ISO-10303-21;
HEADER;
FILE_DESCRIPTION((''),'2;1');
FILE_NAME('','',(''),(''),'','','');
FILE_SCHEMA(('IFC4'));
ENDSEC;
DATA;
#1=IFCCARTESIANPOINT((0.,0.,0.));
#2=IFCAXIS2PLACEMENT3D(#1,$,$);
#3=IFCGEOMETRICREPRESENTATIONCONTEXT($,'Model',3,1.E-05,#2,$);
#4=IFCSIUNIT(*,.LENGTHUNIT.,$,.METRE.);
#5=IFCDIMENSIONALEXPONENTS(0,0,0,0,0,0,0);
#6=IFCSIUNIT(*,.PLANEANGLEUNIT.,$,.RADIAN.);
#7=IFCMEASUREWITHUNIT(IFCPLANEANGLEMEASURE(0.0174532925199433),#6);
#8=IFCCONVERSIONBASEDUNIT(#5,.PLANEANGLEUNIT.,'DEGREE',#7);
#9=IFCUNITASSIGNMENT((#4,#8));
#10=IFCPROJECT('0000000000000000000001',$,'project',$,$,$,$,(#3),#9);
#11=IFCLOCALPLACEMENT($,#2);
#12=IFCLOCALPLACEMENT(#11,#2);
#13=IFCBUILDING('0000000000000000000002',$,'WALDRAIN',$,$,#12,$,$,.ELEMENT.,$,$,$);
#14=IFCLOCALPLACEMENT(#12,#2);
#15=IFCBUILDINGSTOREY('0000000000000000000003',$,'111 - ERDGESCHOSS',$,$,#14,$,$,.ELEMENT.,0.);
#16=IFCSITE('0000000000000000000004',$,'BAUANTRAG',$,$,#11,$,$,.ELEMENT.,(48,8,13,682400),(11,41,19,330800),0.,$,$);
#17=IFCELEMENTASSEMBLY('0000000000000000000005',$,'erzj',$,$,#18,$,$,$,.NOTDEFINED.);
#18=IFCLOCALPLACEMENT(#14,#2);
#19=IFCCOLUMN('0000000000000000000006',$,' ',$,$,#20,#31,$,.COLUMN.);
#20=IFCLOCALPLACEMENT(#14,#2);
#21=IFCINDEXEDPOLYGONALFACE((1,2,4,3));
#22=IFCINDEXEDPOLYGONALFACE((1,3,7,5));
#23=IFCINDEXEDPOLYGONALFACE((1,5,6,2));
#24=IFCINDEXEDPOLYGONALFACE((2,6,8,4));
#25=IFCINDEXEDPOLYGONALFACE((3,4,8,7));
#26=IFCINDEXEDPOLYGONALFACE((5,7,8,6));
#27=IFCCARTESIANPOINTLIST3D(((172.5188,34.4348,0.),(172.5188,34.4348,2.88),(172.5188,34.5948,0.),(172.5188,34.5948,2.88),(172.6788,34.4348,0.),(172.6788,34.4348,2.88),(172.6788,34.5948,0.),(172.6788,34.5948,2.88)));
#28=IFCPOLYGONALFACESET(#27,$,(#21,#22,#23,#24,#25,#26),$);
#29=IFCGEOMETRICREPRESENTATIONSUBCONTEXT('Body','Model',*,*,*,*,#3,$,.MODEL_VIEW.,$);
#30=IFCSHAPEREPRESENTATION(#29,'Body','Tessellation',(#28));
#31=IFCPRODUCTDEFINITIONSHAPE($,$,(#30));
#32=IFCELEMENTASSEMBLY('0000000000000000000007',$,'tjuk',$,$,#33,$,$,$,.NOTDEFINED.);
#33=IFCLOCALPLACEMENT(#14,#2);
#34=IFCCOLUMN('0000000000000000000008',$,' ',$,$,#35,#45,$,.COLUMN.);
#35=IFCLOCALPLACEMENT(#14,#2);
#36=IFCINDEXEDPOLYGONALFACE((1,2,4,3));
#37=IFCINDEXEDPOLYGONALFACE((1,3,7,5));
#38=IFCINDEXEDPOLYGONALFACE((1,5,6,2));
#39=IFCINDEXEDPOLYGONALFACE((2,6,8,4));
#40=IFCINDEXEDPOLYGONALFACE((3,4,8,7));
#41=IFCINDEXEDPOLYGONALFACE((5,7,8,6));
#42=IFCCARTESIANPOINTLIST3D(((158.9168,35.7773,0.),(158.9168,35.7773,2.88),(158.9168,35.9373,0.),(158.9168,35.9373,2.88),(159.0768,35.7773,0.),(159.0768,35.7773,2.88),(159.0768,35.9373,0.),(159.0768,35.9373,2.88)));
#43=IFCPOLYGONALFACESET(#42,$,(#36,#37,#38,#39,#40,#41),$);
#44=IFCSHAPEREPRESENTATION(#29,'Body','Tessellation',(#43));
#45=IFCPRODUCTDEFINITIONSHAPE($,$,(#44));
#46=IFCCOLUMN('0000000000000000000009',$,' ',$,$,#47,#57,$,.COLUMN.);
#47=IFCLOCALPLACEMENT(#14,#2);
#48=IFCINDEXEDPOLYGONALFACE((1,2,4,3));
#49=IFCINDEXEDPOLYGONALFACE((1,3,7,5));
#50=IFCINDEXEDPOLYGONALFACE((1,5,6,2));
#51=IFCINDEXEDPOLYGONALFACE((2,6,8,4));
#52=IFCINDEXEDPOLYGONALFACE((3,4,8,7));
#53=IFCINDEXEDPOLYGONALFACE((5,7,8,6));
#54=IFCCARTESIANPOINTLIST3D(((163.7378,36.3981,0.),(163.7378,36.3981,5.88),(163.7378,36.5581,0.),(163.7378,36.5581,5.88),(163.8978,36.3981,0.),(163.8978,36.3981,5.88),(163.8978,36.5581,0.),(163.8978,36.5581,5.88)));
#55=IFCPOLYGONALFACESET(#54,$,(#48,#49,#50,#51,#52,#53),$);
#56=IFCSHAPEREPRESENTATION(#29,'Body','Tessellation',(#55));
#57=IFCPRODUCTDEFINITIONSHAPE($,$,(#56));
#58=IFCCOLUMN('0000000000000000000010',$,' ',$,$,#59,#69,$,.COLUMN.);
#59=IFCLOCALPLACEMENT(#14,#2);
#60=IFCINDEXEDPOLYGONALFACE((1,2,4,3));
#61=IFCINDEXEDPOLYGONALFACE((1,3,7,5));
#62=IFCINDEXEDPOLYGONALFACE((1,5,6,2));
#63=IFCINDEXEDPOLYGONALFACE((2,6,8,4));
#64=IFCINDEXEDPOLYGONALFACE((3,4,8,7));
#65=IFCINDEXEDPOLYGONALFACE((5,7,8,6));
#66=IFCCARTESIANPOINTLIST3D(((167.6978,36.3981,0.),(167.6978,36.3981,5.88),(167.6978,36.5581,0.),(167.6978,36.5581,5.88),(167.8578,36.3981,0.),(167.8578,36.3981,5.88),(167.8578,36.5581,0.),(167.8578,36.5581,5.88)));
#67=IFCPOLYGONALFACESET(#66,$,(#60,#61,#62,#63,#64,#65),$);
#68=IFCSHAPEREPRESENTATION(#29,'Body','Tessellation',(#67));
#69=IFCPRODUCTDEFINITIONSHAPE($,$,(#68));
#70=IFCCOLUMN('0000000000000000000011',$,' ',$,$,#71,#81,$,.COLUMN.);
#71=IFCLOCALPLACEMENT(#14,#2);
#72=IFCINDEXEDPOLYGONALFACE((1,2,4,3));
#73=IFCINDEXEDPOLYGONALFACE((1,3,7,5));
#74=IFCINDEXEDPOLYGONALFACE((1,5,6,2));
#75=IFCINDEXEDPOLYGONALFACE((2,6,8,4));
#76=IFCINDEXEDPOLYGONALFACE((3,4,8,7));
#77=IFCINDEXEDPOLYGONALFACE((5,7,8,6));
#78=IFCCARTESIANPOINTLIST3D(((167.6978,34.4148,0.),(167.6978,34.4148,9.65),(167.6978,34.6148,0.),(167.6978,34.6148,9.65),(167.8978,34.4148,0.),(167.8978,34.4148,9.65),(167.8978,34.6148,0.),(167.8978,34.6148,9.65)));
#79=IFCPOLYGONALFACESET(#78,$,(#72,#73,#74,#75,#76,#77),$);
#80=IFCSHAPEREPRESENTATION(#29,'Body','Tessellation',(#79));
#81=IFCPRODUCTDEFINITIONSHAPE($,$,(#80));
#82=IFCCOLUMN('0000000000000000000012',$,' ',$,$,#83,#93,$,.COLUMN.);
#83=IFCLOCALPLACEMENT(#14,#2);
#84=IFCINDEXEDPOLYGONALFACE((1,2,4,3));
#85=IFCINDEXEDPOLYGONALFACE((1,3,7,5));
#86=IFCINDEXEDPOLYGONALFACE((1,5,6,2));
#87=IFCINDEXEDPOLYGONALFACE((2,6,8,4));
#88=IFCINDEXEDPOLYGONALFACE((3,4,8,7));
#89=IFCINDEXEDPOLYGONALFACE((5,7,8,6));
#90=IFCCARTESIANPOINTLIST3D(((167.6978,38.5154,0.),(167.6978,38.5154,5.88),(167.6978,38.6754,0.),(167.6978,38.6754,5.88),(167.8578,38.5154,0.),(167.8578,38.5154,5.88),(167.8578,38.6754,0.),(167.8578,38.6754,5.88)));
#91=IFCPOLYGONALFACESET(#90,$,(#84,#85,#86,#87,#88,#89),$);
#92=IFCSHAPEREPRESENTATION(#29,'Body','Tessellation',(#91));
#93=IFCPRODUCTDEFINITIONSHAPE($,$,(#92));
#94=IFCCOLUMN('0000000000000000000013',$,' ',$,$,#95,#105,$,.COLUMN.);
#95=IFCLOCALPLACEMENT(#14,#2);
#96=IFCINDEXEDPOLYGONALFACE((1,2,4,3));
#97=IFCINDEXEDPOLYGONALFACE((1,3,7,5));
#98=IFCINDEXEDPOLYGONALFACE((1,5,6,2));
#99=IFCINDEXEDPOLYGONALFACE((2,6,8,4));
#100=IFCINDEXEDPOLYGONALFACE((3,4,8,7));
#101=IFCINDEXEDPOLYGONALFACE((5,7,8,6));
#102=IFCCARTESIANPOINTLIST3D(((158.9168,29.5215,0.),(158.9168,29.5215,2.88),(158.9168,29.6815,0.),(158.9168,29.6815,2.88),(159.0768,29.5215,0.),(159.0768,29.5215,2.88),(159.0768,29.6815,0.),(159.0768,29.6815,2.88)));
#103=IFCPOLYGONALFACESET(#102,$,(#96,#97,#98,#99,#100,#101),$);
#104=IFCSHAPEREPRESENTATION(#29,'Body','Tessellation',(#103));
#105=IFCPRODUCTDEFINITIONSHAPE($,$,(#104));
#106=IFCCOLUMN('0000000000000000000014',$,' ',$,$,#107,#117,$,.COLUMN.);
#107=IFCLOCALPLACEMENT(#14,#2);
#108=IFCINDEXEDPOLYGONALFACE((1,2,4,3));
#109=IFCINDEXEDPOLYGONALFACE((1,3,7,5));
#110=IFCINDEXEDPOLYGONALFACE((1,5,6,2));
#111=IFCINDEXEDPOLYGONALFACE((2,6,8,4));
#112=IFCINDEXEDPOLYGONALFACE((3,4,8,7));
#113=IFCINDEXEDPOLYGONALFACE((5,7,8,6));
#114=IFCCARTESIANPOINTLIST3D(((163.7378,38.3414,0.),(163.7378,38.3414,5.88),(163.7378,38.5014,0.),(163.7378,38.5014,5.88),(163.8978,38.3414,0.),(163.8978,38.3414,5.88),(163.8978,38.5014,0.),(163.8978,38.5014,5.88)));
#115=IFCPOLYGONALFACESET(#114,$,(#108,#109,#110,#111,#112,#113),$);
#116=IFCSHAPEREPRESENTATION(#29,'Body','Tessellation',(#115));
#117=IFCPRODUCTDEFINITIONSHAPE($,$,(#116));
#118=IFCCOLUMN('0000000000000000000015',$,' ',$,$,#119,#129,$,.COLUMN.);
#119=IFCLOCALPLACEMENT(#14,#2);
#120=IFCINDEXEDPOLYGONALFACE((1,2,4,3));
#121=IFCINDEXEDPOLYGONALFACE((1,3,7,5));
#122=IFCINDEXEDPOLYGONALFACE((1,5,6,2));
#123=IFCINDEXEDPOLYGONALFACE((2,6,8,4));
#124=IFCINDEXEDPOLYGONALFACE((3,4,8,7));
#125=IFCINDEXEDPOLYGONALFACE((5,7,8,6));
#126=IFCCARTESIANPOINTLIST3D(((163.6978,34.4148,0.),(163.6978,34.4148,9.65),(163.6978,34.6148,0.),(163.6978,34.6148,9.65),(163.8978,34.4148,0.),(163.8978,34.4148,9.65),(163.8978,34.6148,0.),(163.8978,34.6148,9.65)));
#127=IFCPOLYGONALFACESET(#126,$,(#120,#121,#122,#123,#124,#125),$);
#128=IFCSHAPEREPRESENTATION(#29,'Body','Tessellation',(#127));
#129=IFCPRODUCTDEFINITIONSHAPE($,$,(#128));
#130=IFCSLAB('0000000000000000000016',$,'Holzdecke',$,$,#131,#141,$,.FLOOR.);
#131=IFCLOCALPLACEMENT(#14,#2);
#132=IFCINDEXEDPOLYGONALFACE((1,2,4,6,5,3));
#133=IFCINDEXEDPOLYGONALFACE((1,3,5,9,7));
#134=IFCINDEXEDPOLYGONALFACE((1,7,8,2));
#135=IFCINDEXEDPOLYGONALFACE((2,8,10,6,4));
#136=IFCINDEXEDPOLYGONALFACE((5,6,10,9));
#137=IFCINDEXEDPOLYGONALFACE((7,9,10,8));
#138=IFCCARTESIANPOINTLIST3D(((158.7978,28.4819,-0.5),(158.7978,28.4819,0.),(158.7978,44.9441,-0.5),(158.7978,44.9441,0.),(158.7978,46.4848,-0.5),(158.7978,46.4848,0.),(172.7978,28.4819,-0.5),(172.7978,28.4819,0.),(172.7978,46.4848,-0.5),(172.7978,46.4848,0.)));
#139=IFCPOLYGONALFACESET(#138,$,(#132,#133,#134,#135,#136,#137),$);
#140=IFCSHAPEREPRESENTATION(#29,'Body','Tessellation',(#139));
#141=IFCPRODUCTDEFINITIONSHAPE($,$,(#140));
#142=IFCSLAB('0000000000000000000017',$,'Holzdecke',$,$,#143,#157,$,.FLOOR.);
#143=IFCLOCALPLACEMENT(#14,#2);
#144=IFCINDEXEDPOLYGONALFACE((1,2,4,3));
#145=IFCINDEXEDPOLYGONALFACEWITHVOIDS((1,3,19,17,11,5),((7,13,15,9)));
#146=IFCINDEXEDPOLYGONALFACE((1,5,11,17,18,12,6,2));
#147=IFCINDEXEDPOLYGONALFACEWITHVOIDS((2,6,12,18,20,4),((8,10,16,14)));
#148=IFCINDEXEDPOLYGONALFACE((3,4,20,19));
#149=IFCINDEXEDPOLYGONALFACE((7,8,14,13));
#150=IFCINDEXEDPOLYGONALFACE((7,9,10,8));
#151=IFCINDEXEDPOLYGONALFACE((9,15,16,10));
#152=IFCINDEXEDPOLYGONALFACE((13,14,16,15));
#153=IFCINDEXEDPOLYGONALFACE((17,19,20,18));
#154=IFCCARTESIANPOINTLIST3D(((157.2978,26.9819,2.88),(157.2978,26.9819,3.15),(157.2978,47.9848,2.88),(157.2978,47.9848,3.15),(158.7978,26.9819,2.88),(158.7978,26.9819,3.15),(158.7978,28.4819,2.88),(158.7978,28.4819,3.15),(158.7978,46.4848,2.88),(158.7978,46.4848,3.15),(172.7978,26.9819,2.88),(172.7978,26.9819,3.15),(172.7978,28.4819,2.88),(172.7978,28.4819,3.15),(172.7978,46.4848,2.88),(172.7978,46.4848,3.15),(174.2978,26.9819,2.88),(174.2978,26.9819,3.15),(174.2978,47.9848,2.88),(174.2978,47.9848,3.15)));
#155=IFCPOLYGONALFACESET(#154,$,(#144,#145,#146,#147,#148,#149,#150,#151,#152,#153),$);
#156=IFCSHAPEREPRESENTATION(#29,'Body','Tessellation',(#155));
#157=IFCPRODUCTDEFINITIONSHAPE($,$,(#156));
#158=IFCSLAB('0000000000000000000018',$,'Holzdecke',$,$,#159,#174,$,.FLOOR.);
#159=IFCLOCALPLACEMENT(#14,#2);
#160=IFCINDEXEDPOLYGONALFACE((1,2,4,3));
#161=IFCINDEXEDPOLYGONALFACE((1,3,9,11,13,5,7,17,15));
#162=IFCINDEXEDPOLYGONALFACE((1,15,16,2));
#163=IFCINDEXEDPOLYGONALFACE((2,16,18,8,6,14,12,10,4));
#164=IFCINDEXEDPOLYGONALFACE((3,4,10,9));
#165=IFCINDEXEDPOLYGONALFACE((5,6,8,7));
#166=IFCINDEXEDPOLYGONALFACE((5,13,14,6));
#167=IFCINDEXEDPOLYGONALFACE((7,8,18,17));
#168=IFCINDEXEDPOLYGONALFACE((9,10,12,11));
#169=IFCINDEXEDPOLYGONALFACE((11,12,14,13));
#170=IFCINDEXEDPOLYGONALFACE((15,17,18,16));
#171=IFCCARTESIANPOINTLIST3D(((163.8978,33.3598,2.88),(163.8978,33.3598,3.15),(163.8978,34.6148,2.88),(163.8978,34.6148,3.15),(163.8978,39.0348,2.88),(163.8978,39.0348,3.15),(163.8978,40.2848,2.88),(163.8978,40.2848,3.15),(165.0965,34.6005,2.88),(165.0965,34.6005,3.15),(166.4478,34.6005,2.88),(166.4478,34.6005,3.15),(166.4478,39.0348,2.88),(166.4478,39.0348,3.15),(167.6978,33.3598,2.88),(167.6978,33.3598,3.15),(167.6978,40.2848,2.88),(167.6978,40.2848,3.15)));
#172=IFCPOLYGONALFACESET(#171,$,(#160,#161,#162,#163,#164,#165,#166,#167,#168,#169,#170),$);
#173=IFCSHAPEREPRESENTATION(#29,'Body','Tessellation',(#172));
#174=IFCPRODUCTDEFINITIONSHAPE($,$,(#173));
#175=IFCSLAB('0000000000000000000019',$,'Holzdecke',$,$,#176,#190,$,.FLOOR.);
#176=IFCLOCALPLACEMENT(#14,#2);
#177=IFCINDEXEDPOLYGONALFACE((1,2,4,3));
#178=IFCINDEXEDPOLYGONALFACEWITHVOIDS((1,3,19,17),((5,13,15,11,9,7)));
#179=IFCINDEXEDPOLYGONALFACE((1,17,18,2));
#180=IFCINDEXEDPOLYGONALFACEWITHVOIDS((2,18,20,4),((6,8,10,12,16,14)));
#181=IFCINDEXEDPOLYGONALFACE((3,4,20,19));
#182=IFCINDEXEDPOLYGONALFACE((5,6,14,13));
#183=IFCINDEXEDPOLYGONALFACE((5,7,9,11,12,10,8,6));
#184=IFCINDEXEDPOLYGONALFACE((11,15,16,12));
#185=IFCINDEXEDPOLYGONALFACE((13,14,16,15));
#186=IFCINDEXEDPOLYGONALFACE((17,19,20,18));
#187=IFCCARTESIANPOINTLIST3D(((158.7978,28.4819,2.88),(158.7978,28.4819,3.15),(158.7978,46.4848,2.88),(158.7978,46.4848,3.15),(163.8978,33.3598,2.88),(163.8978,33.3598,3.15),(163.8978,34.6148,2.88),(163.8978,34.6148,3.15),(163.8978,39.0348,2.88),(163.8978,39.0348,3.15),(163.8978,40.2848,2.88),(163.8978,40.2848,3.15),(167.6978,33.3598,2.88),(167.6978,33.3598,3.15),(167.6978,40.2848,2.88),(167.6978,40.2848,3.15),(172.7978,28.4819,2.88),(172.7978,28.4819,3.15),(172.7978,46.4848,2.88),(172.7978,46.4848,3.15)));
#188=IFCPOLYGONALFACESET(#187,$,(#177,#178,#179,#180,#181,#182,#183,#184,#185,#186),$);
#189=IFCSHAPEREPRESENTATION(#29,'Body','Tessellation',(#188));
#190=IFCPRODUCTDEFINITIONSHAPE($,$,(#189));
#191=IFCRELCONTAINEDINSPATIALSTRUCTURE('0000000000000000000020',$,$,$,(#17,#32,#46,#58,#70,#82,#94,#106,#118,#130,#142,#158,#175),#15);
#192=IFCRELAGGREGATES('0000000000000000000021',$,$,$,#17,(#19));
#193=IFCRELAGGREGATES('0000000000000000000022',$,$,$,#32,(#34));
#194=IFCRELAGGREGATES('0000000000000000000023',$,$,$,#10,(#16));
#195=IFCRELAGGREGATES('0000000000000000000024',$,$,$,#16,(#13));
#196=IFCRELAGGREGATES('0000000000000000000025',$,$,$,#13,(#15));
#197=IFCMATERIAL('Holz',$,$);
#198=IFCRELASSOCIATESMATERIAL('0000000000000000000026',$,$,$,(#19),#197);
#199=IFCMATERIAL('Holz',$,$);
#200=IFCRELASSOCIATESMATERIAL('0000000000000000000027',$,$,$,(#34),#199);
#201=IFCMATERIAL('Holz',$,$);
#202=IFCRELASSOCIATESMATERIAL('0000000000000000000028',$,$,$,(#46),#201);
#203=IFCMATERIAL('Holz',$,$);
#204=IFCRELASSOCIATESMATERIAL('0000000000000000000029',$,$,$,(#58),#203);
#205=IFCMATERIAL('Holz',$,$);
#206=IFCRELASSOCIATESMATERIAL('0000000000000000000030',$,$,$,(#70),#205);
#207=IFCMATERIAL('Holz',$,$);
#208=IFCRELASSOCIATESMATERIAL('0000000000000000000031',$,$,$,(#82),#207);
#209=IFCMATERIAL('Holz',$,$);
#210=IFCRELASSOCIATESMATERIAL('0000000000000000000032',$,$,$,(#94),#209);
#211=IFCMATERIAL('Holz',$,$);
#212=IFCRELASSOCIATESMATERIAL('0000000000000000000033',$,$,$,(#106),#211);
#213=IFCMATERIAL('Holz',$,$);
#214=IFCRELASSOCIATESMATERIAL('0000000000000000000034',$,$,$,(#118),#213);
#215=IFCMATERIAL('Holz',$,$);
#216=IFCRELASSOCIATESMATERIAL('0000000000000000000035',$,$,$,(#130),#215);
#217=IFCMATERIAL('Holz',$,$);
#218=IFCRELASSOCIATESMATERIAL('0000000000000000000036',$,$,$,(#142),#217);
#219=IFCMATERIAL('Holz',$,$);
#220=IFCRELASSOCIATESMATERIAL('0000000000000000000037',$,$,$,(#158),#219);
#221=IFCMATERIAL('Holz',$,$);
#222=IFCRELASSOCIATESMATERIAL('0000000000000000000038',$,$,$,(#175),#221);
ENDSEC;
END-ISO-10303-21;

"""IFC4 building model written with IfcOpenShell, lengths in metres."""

from ifc_helpers import new_model, entity, si_unit, converted_unit, frame, frame_2d, origin, origin_with_axes, place, context, subcontext, project, spatial, polyline, rectangle, outline, extrude, material, element, aggregate, save


model = new_model("IFC4")

# Units and contexts
model_context = context("Model", 3, precision=1e-05, world=origin())
body_context = subcontext(model_context, "Body", "Model", "MODEL_VIEW")
ifc_project = project(units=[si_unit("LENGTHUNIT", "METRE"), converted_unit("PLANEANGLEUNIT", "DEGREE", entity("IfcPlaneAngleMeasure", 0.0174532925199433), si_unit("PLANEANGLEUNIT", "RADIAN"), dimensions=[0, 0, 0, 0, 0, 0, 0])], contexts=[model_context])

# Site, building, storey
site_placement = place(None, origin())
site = spatial("IfcSite", under=ifc_project, at=site_placement, Name="BAUANTRAG", CompositionType="ELEMENT", RefLatitude=(48, 8, 13, 682400), RefLongitude=(11, 41, 19, 330800), RefElevation=0.0)
building_placement = place(site_placement, origin())
building = spatial("IfcBuilding", under=site, at=building_placement, Name="WALDRAIN", CompositionType="ELEMENT")
storey_placement = place(building_placement, origin())
storey = spatial("IfcBuildingStorey", under=building, at=storey_placement, Name="111 - ERDGESCHOSS", CompositionType="ELEMENT", Elevation=0.0)

# Element assemblies, columns
assembly_1_placement = place(storey_placement, origin())
assembly_1 = element("IfcElementAssembly", 1, at=assembly_1_placement, inside=storey, Name="erzj", PredefinedType="NOTDEFINED")
ifc_material_1 = material(Name="Holz")
column_1_placement = place(assembly_1_placement, frame((172.5188, 34.4348, 0.0)))
column_1 = element("IfcColumn", 2, at=column_1_placement, material=ifc_material_1, Name=" ", PredefinedType="COLUMN", context=body_context, shape_type="SweptSolid", body=[
    extrude(rectangle(XDim=0.16, YDim=0.16, at=frame_2d((0.08, 0.08), x_axis=(1.0, 0.0))), origin_with_axes(), (0.0, 0.0, 1.0), 2.88),
])
aggregate(assembly_1, [column_1])
assembly_2_placement = place(storey_placement, origin())
assembly_2 = element("IfcElementAssembly", 3, at=assembly_2_placement, inside=storey, Name="tjuk", PredefinedType="NOTDEFINED")
ifc_material_2 = material(Name="Holz")
column_2_placement = place(assembly_2_placement, frame((158.9168, 35.7773, 0.0)))
column_2 = element("IfcColumn", 4, at=column_2_placement, material=ifc_material_2, Name=" ", PredefinedType="COLUMN", context=body_context, shape_type="SweptSolid", body=[
    extrude(rectangle(XDim=0.16, YDim=0.16, at=frame_2d((0.08, 0.08), x_axis=(1.0, 0.0))), origin_with_axes(), (0.0, 0.0, 1.0), 2.88),
])
aggregate(assembly_2, [column_2])

# Columns
ifc_material_3 = material(Name="Holz")
column_3_placement = place(storey_placement, frame((163.7378, 36.3981, 0.0)))
element("IfcColumn", 5, at=column_3_placement, inside=storey, material=ifc_material_3, Name=" ", PredefinedType="COLUMN", context=body_context, shape_type="SweptSolid", body=[
    extrude(rectangle(XDim=0.16, YDim=0.16, at=frame_2d((0.08, 0.08), x_axis=(1.0, 0.0))), origin_with_axes(), (0.0, 0.0, 1.0), 5.88),
])
ifc_material_4 = material(Name="Holz")
column_4_placement = place(storey_placement, frame((167.6978, 36.3981, 0.0)))
element("IfcColumn", 6, at=column_4_placement, inside=storey, material=ifc_material_4, Name=" ", PredefinedType="COLUMN", context=body_context, shape_type="SweptSolid", body=[
    extrude(rectangle(XDim=0.16, YDim=0.16, at=frame_2d((0.08, 0.08), x_axis=(1.0, 0.0))), origin_with_axes(), (0.0, 0.0, 1.0), 5.88),
])
ifc_material_5 = material(Name="Holz")
column_5_placement = place(storey_placement, frame((167.6978, 34.4148, 0.0)))
element("IfcColumn", 7, at=column_5_placement, inside=storey, material=ifc_material_5, Name=" ", PredefinedType="COLUMN", context=body_context, shape_type="SweptSolid", body=[
    extrude(rectangle(XDim=0.2, YDim=0.2, at=frame_2d((0.1, 0.1), x_axis=(1.0, 0.0))), origin_with_axes(), (0.0, 0.0, 1.0), 9.65),
])
ifc_material_6 = material(Name="Holz")
column_6_placement = place(storey_placement, frame((167.6978, 38.5154, 0.0)))
element("IfcColumn", 8, at=column_6_placement, inside=storey, material=ifc_material_6, Name=" ", PredefinedType="COLUMN", context=body_context, shape_type="SweptSolid", body=[
    extrude(rectangle(XDim=0.16, YDim=0.16, at=frame_2d((0.08, 0.08), x_axis=(1.0, 0.0))), origin_with_axes(), (0.0, 0.0, 1.0), 5.88),
])
ifc_material_7 = material(Name="Holz")
column_7_placement = place(storey_placement, frame((158.9168, 29.5215, 0.0)))
element("IfcColumn", 9, at=column_7_placement, inside=storey, material=ifc_material_7, Name=" ", PredefinedType="COLUMN", context=body_context, shape_type="SweptSolid", body=[
    extrude(rectangle(XDim=0.16, YDim=0.16, at=frame_2d((0.08, 0.08), x_axis=(1.0, 0.0))), origin_with_axes(), (0.0, 0.0, 1.0), 2.88),
])
ifc_material_8 = material(Name="Holz")
column_8_placement = place(storey_placement, frame((163.7378, 38.3414, 0.0)))
element("IfcColumn", 10, at=column_8_placement, inside=storey, material=ifc_material_8, Name=" ", PredefinedType="COLUMN", context=body_context, shape_type="SweptSolid", body=[
    extrude(rectangle(XDim=0.16, YDim=0.16, at=frame_2d((0.08, 0.08), x_axis=(1.0, 0.0))), origin_with_axes(), (0.0, 0.0, 1.0), 5.88),
])
ifc_material_9 = material(Name="Holz")
column_9_placement = place(storey_placement, frame((163.6978, 34.4148, 0.0)))
element("IfcColumn", 11, at=column_9_placement, inside=storey, material=ifc_material_9, Name=" ", PredefinedType="COLUMN", context=body_context, shape_type="SweptSolid", body=[
    extrude(rectangle(XDim=0.2, YDim=0.2, at=frame_2d((0.1, 0.1), x_axis=(1.0, 0.0))), origin_with_axes(), (0.0, 0.0, 1.0), 9.65),
])

# Slabs
ifc_material_10 = material(Name="Holz")
slab_1_placement = place(storey_placement, frame((158.7978, 28.4819, -0.5)))
element("IfcSlab", 12, at=slab_1_placement, inside=storey, material=ifc_material_10, Name="Holzdecke", PredefinedType="FLOOR", context=body_context, shape_type="SweptSolid", body=[
    extrude(outline(polyline([(0.0, 16.4622), (0.0, 0.0), (14.0, 0.0), (14.0, 18.0029), (0.0, 18.0029), (0.0, 16.4622)])), origin_with_axes(), (0.0, 0.0, 1.0), 0.5),
])
ifc_material_11 = material(Name="Holz")
slab_2_placement = place(storey_placement, frame((157.2978, 26.9819, 2.88)))
element("IfcSlab", 13, at=slab_2_placement, inside=storey, material=ifc_material_11, Name="Holzdecke", PredefinedType="FLOOR", context=body_context, shape_type="SweptSolid", body=[
    extrude(outline(polyline([(17.0, 0.0), (17.0, 21.0029), (0.0, 21.0029), (0.0, 0.0), (1.5, 0.0), (15.5, 0.0), (17.0, 0.0)]), holes=[polyline([(15.5, 19.5029), (15.5, 1.5), (1.5, 1.5), (1.5, 19.5029), (15.5, 19.5029)])]), origin_with_axes(), (0.0, 0.0, 1.0), 0.27),
])
ifc_material_12 = material(Name="Holz")
slab_3_placement = place(storey_placement, frame((163.8978, 33.3598, 2.88)))
element("IfcSlab", 14, at=slab_3_placement, inside=storey, material=ifc_material_12, Name="Holzdecke", PredefinedType="FLOOR", context=body_context, shape_type="SweptSolid", body=[
    extrude(outline(polyline([(0.0, 6.925), (0.0, 5.675), (2.55, 5.675), (2.55, 1.2408), (1.1988, 1.2408), (0.0, 1.255), (0.0, 0.0), (3.8, 0.0), (3.8, 6.925), (0.0, 6.925)])), origin_with_axes(), (0.0, 0.0, 1.0), 0.27),
])

# Slab, opening
ifc_material_13 = material(Name="Holz")
slab_4_placement = place(storey_placement, frame((158.7978, 28.4819, 2.88)))
slab_4 = element("IfcSlab", 15, at=slab_4_placement, inside=storey, material=ifc_material_13, Name="Holzdecke", PredefinedType="FLOOR", context=body_context, shape_type="SweptSolid", body=[
    extrude(outline(polyline([(14.0, 0.0), (14.0, 18.0029), (0.0, 18.0029), (0.0, 0.0), (14.0, 0.0)]), holes=[polyline([(5.1, 10.5529), (5.1, 11.8029), (8.9, 11.8029), (8.9, 4.8779), (5.1, 4.8779), (5.1, 6.1329), (6.2988, 6.1186), (7.65, 6.1186), (7.65, 10.5529), (5.1, 10.5529)])]), origin_with_axes(), (0.0, 0.0, 1.0), 0.27),
])
opening_1_placement = place(slab_4_placement, frame((5.1, 4.8779, 0.0)))
element("IfcOpeningElement", 16, at=opening_1_placement, cuts=slab_4, ObjectType="Opening", context=body_context, shape_type="SweptSolid", body=[
    extrude(rectangle(XDim=3.8, YDim=6.925, at=frame_2d((0.0, 0.0), x_axis=(-1.0, 0.0))), frame((1.9, 3.4625, 0.0), z_axis=(0.0, 0.0, 1.0), x_axis=(1.0, 0.0, 0.0)), (0.0, 0.0, 1.0), 0.27),
])

save(model, "model.ifc")
